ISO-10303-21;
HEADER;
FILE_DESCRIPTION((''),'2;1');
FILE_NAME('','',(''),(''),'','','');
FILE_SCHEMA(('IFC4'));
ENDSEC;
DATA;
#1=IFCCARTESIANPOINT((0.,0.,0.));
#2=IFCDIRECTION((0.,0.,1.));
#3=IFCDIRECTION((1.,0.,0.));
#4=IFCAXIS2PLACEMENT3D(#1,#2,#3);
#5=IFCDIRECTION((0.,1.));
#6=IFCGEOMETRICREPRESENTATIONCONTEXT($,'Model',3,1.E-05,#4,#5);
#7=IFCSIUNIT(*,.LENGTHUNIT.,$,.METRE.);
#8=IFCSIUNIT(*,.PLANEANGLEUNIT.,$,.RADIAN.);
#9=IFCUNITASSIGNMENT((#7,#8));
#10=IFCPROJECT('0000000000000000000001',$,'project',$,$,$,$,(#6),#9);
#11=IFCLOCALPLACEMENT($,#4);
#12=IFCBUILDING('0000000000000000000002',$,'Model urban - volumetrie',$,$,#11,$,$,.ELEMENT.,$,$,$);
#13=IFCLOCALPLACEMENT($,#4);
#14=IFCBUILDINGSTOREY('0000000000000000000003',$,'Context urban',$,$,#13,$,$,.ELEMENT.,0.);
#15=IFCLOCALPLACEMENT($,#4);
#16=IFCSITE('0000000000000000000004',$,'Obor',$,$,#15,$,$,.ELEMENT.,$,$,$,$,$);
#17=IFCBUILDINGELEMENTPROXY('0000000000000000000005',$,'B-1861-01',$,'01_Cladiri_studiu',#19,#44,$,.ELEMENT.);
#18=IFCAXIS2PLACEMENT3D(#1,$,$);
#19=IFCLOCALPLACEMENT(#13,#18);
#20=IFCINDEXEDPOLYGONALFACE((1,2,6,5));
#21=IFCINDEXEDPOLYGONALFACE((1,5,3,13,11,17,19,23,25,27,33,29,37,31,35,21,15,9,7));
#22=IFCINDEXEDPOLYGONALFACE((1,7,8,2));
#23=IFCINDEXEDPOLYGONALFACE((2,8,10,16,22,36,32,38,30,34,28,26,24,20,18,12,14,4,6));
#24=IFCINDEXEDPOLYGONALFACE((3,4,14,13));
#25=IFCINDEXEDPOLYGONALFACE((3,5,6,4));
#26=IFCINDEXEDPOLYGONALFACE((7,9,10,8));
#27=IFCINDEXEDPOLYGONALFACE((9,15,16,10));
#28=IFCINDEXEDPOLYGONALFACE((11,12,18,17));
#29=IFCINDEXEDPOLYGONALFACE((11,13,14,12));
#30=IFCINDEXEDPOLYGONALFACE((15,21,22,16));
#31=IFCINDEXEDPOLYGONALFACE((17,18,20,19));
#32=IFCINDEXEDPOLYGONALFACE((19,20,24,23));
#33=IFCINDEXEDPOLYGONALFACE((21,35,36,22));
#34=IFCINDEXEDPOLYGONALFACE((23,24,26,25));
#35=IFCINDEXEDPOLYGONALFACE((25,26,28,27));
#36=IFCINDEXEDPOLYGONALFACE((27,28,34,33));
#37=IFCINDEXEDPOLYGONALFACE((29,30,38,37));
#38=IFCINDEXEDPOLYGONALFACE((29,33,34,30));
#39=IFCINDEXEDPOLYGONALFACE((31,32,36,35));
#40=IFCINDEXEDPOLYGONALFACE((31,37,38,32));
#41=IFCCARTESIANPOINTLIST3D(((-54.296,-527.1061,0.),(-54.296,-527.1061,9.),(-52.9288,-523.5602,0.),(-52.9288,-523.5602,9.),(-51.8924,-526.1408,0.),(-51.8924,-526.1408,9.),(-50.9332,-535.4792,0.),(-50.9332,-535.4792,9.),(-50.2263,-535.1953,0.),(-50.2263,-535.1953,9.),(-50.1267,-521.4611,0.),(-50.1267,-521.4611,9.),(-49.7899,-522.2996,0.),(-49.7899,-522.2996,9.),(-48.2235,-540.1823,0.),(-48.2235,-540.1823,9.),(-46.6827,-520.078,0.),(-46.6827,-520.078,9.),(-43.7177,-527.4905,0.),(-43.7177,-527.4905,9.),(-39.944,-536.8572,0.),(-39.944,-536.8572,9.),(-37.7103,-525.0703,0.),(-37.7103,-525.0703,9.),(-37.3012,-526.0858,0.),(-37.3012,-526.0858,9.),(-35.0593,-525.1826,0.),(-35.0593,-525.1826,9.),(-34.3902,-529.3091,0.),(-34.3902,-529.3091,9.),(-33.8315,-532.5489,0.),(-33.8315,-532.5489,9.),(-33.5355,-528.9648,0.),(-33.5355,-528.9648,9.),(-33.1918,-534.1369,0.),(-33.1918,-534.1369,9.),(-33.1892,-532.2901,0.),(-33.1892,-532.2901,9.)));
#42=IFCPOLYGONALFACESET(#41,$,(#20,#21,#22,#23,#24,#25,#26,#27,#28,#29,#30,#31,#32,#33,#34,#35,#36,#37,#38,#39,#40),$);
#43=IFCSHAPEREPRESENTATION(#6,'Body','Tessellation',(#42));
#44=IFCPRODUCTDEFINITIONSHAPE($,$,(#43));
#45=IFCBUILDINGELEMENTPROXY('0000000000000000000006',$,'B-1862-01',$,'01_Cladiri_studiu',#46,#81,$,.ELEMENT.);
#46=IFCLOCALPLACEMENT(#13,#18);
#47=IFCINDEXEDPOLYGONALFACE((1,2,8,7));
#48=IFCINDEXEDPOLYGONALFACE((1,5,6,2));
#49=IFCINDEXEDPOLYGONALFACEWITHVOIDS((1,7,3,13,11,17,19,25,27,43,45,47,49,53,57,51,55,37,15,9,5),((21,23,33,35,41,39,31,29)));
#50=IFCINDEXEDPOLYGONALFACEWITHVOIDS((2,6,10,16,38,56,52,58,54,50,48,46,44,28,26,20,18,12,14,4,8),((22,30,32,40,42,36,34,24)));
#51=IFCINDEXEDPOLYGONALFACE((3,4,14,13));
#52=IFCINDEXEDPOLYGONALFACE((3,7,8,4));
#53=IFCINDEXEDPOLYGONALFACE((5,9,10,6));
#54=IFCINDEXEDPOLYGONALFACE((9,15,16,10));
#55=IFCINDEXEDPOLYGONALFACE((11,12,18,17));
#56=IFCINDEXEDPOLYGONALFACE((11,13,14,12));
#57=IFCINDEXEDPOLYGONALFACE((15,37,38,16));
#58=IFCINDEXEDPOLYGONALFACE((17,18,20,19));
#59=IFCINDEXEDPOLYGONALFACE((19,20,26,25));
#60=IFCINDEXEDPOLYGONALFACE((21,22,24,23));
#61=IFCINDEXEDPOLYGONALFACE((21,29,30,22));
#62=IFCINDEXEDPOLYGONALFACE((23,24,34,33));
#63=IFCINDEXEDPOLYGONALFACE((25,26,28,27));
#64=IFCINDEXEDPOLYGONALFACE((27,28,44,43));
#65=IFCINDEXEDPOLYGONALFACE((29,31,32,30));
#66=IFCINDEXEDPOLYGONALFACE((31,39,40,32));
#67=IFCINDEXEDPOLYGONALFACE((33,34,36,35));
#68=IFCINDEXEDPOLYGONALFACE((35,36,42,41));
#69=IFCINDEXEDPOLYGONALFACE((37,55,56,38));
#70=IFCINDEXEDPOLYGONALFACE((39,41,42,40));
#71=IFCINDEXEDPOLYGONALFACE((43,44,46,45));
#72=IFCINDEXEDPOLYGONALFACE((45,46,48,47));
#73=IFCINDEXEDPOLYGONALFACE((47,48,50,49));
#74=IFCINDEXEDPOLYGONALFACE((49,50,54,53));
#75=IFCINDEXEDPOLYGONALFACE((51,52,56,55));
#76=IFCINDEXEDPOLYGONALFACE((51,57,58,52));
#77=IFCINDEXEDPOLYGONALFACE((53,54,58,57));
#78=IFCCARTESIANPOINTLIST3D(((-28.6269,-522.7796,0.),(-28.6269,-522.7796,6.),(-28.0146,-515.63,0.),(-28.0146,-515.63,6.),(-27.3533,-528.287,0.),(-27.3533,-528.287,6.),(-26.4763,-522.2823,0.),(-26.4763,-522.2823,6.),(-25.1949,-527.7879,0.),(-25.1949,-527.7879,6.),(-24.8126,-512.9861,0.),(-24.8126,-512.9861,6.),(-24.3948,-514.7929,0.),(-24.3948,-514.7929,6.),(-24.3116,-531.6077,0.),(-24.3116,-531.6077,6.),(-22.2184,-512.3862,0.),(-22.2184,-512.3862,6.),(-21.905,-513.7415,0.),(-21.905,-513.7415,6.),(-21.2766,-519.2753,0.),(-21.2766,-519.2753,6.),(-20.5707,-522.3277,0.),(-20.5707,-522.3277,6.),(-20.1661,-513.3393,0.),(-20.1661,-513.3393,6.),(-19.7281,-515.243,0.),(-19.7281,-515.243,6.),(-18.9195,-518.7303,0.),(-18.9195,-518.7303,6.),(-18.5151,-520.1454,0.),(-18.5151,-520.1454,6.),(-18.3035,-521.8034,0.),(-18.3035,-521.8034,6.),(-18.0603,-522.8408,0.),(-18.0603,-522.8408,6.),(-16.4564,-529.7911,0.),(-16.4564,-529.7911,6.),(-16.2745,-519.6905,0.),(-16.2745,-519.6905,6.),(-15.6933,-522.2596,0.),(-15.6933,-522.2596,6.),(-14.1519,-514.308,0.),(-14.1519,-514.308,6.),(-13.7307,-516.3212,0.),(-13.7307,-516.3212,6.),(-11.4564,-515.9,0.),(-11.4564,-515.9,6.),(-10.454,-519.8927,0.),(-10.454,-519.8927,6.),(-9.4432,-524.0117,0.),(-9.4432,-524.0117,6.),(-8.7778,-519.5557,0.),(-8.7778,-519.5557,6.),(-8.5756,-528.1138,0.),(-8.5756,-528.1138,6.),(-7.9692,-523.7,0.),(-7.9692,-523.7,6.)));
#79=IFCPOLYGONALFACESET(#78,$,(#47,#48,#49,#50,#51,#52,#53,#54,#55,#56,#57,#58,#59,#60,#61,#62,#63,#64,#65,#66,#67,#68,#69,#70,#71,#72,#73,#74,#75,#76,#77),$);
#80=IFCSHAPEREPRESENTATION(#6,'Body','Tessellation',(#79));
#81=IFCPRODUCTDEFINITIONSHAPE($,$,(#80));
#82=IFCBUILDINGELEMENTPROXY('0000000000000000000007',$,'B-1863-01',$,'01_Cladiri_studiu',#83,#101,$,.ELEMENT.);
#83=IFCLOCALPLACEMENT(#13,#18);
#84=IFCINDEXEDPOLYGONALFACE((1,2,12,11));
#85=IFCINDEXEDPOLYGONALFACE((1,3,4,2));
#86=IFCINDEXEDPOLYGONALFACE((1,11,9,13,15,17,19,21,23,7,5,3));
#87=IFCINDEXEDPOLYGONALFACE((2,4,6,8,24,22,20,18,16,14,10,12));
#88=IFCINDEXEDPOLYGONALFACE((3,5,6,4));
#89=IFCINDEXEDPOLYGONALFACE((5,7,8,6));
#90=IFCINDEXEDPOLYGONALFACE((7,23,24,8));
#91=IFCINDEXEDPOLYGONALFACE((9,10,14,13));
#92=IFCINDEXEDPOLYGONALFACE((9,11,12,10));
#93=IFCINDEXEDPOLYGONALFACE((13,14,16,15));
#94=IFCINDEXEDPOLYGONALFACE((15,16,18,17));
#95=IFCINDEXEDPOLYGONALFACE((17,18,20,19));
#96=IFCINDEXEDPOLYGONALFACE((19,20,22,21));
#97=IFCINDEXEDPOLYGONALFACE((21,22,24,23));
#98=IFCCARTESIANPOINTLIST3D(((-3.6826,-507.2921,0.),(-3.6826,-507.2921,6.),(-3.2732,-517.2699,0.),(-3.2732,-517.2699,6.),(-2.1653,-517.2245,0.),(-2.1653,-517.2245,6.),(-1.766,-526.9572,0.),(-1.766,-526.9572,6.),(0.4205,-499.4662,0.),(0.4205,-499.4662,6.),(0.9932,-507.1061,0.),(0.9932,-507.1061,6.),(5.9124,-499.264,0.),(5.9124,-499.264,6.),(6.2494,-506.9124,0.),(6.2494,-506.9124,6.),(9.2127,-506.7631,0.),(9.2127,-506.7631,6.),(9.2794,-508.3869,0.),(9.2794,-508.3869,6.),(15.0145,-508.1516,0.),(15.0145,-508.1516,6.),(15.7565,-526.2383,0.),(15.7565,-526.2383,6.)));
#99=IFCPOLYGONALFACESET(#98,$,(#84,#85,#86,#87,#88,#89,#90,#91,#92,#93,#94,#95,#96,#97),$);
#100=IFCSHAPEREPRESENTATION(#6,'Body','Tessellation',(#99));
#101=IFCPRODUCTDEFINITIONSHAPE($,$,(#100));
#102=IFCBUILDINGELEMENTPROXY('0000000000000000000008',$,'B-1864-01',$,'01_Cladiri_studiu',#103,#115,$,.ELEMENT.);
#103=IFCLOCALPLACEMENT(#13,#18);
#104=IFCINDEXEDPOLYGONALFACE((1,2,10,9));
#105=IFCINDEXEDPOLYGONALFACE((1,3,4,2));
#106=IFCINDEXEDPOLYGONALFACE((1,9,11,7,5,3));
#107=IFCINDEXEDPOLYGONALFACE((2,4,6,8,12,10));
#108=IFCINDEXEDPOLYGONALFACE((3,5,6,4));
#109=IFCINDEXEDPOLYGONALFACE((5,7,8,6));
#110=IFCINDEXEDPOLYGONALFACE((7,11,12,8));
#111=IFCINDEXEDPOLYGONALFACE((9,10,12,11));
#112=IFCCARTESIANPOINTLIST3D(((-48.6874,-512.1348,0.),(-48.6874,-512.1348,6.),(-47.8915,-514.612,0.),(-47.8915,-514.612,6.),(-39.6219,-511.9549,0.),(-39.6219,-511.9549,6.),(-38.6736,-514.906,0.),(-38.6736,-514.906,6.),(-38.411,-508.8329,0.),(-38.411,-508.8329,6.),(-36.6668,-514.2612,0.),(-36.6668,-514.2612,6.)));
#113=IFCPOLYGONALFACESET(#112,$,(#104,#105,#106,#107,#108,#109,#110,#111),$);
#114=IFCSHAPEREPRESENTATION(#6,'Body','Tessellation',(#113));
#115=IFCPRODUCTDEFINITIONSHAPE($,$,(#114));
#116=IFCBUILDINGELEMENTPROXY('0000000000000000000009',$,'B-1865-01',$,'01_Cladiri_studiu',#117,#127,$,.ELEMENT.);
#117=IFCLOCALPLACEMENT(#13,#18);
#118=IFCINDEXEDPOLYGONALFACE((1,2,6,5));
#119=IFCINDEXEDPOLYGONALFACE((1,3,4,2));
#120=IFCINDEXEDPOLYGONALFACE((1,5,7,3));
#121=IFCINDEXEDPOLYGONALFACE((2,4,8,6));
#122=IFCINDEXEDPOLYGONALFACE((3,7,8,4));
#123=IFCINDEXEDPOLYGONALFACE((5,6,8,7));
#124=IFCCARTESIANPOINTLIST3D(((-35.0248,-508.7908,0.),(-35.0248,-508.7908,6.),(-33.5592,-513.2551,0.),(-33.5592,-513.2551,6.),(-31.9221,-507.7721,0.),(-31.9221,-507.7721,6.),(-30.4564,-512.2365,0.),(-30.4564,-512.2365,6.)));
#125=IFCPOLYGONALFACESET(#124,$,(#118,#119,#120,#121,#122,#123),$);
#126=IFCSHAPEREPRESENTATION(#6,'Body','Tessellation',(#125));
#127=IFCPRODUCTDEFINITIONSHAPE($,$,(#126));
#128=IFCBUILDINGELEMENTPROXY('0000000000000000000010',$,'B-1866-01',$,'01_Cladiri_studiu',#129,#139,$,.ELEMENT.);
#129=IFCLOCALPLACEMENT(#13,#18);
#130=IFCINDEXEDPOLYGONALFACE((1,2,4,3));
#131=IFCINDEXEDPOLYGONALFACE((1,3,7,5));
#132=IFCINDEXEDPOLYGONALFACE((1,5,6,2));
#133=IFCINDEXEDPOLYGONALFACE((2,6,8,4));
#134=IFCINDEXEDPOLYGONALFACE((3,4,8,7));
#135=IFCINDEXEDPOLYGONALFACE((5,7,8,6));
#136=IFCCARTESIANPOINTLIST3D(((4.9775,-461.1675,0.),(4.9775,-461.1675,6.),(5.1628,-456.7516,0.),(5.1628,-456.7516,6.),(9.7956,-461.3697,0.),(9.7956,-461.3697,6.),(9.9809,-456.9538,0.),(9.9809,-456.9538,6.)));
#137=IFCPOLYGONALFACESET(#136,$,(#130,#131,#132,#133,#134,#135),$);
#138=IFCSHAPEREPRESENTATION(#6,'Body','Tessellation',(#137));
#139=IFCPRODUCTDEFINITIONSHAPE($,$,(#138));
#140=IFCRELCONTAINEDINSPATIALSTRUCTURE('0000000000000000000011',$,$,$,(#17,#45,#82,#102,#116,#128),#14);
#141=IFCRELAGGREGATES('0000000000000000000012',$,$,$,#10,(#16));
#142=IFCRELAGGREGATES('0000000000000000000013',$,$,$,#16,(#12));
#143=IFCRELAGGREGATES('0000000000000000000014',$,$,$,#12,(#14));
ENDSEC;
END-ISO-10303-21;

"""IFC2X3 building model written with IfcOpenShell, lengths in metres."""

from ifc_helpers import new_model, si_unit, direction, origin_with_axes, place, context, project, spatial, polyline, outline, extrude, element, save


model = new_model("IFC2X3")

# Units and contexts
model_context = context("Model", 3, precision=1e-05, world=origin_with_axes(), true_north=direction((0.0, 1.0)))
ifc_project = project(units=[si_unit("LENGTHUNIT", "METRE"), si_unit("PLANEANGLEUNIT", "RADIAN")], contexts=[model_context])

# Site, building, storey
site_placement = place(None, origin_with_axes())
site = spatial("IfcSite", under=ifc_project, at=site_placement, Name="Obor", CompositionType="ELEMENT")
building_placement = place(None, origin_with_axes())
building = spatial("IfcBuilding", under=site, at=building_placement, Name="Model urban - volumetrie", CompositionType="ELEMENT")
storey_placement = place(None, origin_with_axes())
storey = spatial("IfcBuildingStorey", under=building, at=storey_placement, Name="Context urban", CompositionType="ELEMENT", Elevation=0.0)

# Building element proxies
proxy_1_placement = place(None, origin_with_axes())
element("IfcBuildingElementProxy", 1, at=proxy_1_placement, inside=storey, Name="B-1861-01", ObjectType="01_Cladiri_studiu", CompositionType="ELEMENT", context=model_context, shape_type="SweptSolid", body=[
    extrude(outline(polyline([(-51.8924, -526.1408), (-54.296, -527.1061), (-50.9332, -535.4792), (-50.2263, -535.1953), (-48.2235, -540.1823), (-39.944, -536.8572), (-33.1918, -534.1369), (-33.8315, -532.5489), (-33.1892, -532.2901), (-34.3902, -529.3091), (-33.5355, -528.9648), (-35.0593, -525.1826), (-37.3012, -526.0858), (-37.7103, -525.0703), (-43.7177, -527.4905), (-46.6827, -520.078), (-50.1267, -521.4611), (-49.7899, -522.2996), (-52.9288, -523.5602), (-51.8924, -526.1408)])), origin_with_axes(), (0.0, 0.0, 1.0), 9.0),
])
proxy_2_placement = place(None, origin_with_axes())
element("IfcBuildingElementProxy", 2, at=proxy_2_placement, inside=storey, Name="B-1862-01", ObjectType="01_Cladiri_studiu", CompositionType="ELEMENT", context=model_context, shape_type="SweptSolid", body=[
    extrude(outline(polyline([(-28.6269, -522.7796), (-27.3533, -528.287), (-25.1949, -527.7879), (-24.3116, -531.6077), (-16.4564, -529.7911), (-18.0603, -522.8408), (-16.4564, -529.7911), (-8.5756, -528.1138), (-9.4432, -524.0117), (-7.9692, -523.7), (-8.7778, -519.5557), (-10.454, -519.8927), (-11.4564, -515.9), (-13.7307, -516.3212), (-14.1519, -514.308), (-19.7281, -515.243), (-20.1661, -513.3393), (-21.905, -513.7415), (-22.2184, -512.3862), (-24.8126, -512.9861), (-24.3948, -514.7929), (-28.0146, -515.63), (-26.4763, -522.2823), (-28.6269, -522.7796)]), holes=[polyline([(-15.6933, -522.2596), (-18.0603, -522.8408), (-18.3035, -521.8034), (-20.5707, -522.3277), (-21.2766, -519.2753), (-18.9195, -518.7303), (-18.5151, -520.1454), (-16.2745, -519.6905), (-15.6933, -522.2596)])]), origin_with_axes(), (0.0, 0.0, 1.0), 6.0),
])
proxy_3_placement = place(None, origin_with_axes())
element("IfcBuildingElementProxy", 3, at=proxy_3_placement, inside=storey, Name="B-1863-01", ObjectType="01_Cladiri_studiu", CompositionType="ELEMENT", context=model_context, shape_type="SweptSolid", body=[
    extrude(outline(polyline([(-1.766, -526.9572), (15.7565, -526.2383), (15.0145, -508.1516), (9.2794, -508.3869), (9.2127, -506.7631), (6.2494, -506.9124), (5.9124, -499.264), (0.4205, -499.4662), (0.9932, -507.1061), (-3.6826, -507.2921), (-3.2732, -517.2699), (-2.1653, -517.2245), (-1.766, -526.9572)])), origin_with_axes(), (0.0, 0.0, 1.0), 6.0),
])
proxy_4_placement = place(None, origin_with_axes())
element("IfcBuildingElementProxy", 4, at=proxy_4_placement, inside=storey, Name="B-1864-01", ObjectType="01_Cladiri_studiu", CompositionType="ELEMENT", context=model_context, shape_type="SweptSolid", body=[
    extrude(outline(polyline([(-38.6736, -514.906), (-36.6668, -514.2612), (-38.411, -508.8329), (-48.6874, -512.1348), (-47.8915, -514.612), (-39.6219, -511.9549), (-38.6736, -514.906)])), origin_with_axes(), (0.0, 0.0, 1.0), 6.0),
])
proxy_5_placement = place(None, origin_with_axes())
element("IfcBuildingElementProxy", 5, at=proxy_5_placement, inside=storey, Name="B-1865-01", ObjectType="01_Cladiri_studiu", CompositionType="ELEMENT", context=model_context, shape_type="SweptSolid", body=[
    extrude(outline(polyline([(-33.5592, -513.2551), (-30.4564, -512.2365), (-31.9221, -507.7721), (-35.0248, -508.7908), (-33.5592, -513.2551)])), origin_with_axes(), (0.0, 0.0, 1.0), 6.0),
])
proxy_6_placement = place(None, origin_with_axes())
element("IfcBuildingElementProxy", 6, at=proxy_6_placement, inside=storey, Name="B-1866-01", ObjectType="01_Cladiri_studiu", CompositionType="ELEMENT", context=model_context, shape_type="SweptSolid", body=[
    extrude(outline(polyline([(9.7956, -461.3697), (9.9809, -456.9538), (5.1628, -456.7516), (4.9775, -461.1675), (9.7956, -461.3697)])), origin_with_axes(), (0.0, 0.0, 1.0), 6.0),
])

save(model, "model.ifc")
